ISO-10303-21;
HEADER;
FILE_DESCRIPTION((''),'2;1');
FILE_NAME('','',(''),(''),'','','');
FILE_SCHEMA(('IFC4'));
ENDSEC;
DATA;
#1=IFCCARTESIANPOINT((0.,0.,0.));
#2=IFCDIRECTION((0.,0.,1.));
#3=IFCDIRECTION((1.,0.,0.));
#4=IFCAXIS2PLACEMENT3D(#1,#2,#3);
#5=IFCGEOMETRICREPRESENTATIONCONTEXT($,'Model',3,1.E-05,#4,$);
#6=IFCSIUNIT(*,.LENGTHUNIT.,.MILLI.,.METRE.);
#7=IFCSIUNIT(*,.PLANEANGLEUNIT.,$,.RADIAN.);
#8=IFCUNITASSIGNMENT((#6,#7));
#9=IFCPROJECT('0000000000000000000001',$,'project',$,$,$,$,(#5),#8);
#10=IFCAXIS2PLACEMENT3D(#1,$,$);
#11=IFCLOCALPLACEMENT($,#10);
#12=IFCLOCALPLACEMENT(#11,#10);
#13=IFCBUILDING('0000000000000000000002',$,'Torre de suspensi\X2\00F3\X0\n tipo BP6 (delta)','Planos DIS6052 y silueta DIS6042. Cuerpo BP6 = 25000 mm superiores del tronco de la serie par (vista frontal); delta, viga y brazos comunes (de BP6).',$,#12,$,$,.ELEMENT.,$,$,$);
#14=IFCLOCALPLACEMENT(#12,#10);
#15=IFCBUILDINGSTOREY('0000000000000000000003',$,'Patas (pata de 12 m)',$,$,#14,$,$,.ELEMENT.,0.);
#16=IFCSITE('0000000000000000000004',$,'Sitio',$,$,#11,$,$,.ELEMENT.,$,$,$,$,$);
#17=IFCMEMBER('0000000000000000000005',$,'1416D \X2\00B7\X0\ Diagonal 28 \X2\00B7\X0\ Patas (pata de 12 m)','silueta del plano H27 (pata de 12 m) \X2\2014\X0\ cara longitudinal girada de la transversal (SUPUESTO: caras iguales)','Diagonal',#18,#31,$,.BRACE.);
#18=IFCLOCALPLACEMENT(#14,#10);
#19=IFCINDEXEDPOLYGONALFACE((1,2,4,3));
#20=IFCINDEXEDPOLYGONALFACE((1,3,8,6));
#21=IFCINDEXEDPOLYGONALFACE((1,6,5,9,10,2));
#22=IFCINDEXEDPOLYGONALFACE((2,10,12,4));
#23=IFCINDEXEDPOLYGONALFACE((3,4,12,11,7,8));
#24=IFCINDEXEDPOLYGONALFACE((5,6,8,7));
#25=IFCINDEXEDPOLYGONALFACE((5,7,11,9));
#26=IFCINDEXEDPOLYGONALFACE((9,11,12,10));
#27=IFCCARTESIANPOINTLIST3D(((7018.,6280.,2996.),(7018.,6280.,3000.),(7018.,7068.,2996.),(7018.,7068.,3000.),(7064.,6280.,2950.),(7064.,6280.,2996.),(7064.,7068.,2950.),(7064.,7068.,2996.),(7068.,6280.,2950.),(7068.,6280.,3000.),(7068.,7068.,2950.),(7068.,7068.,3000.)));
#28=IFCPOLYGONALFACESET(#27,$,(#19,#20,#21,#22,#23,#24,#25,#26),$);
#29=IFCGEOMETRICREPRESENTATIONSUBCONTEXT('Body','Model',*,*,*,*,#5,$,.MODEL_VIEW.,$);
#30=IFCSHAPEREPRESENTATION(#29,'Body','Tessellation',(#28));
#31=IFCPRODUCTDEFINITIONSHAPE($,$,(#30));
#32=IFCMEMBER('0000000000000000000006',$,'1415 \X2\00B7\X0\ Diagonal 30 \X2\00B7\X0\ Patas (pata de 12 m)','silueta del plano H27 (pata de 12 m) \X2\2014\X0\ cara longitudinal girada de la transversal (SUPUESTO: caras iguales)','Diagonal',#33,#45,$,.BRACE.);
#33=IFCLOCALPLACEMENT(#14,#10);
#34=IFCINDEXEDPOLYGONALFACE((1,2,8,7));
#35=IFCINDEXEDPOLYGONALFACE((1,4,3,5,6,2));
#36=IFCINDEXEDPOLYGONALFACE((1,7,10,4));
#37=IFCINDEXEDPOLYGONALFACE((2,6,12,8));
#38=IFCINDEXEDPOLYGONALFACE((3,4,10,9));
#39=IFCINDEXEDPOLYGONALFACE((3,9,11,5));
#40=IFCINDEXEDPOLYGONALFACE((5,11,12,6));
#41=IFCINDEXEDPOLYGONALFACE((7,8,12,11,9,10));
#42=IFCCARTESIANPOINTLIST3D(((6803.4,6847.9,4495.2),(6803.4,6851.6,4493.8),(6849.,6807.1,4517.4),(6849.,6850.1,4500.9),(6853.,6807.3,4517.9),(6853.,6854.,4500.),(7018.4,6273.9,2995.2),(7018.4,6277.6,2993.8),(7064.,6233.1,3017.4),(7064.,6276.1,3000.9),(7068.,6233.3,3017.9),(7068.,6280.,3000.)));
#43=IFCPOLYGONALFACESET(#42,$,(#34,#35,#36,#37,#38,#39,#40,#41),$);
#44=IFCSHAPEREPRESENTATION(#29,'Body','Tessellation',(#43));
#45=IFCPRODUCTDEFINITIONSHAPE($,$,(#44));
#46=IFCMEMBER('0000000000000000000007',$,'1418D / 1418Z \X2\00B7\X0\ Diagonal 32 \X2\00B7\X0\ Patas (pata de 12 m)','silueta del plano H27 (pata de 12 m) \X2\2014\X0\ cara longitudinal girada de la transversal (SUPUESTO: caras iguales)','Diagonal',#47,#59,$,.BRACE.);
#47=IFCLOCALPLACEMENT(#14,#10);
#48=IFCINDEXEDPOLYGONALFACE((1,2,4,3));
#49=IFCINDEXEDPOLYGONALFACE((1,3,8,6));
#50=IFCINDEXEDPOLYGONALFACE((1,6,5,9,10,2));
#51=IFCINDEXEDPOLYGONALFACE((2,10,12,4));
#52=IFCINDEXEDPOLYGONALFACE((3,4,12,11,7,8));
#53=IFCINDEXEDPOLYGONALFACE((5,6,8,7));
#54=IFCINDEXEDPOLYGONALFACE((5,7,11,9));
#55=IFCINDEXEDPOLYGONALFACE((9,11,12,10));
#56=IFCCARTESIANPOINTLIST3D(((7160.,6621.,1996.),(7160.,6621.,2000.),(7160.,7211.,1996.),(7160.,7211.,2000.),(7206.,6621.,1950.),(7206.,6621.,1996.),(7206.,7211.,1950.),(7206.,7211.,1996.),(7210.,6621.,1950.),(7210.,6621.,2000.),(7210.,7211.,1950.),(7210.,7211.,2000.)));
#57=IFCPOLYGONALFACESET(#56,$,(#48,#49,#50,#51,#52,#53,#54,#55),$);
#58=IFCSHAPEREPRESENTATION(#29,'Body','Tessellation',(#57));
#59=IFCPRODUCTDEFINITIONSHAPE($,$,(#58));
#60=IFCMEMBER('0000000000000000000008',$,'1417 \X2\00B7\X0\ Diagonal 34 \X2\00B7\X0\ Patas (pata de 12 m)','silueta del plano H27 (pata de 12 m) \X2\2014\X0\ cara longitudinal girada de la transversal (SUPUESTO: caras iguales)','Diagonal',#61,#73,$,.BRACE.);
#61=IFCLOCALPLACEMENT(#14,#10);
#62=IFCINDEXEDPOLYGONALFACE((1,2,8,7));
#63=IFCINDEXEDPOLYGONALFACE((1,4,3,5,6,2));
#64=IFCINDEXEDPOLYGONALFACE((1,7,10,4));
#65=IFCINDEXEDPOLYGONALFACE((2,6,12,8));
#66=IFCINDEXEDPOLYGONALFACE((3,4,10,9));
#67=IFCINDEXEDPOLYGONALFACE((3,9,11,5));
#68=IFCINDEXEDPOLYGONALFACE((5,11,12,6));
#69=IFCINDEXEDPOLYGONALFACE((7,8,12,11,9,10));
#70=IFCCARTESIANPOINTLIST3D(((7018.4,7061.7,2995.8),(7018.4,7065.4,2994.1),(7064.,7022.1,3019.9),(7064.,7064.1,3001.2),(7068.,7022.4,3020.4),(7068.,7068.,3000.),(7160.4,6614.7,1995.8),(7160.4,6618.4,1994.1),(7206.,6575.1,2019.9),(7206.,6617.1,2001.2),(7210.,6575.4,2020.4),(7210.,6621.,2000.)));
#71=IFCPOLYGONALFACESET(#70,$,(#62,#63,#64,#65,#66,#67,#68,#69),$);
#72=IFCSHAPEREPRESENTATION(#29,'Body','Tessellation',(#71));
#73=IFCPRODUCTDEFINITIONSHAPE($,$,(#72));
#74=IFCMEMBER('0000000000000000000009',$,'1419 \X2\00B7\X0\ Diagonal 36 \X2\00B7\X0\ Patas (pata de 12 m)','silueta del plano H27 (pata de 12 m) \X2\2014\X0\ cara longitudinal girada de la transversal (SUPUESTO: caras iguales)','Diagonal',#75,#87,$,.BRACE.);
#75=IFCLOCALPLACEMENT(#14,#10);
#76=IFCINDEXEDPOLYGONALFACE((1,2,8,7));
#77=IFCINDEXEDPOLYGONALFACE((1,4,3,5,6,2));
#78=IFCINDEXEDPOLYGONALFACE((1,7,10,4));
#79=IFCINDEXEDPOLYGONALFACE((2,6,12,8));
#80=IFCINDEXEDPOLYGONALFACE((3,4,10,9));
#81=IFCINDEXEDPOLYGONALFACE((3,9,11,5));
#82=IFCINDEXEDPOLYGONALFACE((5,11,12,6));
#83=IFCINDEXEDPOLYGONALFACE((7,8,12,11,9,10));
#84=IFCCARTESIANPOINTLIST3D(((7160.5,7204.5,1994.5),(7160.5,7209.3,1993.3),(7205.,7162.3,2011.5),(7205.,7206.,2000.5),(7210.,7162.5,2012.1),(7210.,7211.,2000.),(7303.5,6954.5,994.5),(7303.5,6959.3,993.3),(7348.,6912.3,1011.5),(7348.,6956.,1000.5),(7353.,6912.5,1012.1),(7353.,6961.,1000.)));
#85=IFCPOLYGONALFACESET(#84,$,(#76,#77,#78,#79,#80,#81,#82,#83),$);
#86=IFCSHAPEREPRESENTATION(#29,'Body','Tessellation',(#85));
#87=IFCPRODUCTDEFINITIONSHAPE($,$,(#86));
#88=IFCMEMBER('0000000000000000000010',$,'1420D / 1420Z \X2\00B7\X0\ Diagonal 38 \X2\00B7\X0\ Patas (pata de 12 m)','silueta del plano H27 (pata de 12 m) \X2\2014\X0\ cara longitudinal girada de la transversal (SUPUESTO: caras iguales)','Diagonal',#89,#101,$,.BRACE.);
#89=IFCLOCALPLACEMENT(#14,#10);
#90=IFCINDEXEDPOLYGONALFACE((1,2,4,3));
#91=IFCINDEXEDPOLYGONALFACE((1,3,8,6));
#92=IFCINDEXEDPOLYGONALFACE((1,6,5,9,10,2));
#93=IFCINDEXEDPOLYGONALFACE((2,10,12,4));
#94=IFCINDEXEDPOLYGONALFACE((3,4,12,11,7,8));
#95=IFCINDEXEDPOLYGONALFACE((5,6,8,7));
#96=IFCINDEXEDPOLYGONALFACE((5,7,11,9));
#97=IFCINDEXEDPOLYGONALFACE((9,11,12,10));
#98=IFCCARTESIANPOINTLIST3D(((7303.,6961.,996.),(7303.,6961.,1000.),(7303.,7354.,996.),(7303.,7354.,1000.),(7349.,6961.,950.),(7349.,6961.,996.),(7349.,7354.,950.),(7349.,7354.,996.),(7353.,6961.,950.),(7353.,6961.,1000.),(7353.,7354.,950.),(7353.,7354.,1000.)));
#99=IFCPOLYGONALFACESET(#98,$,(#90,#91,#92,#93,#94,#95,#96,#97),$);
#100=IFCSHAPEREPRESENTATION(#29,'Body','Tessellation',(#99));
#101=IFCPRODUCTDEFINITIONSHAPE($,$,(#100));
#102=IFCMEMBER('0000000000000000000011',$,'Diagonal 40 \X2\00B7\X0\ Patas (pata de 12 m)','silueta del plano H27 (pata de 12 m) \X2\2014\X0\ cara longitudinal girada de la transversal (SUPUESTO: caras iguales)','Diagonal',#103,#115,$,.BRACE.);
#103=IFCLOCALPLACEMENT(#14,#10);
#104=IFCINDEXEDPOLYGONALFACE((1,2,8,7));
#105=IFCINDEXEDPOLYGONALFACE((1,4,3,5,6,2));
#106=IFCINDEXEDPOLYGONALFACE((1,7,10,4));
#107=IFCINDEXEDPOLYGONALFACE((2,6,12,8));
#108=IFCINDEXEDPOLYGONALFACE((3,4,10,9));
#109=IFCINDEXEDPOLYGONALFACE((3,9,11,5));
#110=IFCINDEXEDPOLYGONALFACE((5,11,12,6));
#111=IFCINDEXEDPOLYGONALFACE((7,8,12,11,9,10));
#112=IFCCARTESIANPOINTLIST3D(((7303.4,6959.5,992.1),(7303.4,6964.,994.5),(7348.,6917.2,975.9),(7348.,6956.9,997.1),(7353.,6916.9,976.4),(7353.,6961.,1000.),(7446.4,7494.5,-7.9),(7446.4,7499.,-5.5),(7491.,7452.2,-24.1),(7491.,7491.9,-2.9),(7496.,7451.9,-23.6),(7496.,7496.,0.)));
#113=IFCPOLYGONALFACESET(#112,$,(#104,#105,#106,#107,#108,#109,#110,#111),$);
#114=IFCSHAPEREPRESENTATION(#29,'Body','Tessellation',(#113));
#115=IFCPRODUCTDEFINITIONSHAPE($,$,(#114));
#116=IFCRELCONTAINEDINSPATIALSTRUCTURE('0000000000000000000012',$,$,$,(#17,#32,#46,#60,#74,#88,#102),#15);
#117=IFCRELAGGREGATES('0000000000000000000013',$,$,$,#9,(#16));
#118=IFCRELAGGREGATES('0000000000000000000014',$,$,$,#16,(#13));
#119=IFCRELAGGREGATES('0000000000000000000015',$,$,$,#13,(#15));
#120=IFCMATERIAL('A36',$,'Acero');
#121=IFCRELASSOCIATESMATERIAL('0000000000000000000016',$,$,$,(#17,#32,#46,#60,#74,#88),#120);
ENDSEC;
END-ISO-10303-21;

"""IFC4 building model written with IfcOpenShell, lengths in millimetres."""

from ifc_helpers import new_model, si_unit, frame, frame_2d, origin, origin_with_axes, place, context, subcontext, project, spatial, l_section, extrude, material, element, save


model = new_model("IFC4")

# Units and contexts
model_context = context("Model", 3, precision=1e-05, world=origin_with_axes())
body_context = subcontext(model_context, "Body", "Model", "MODEL_VIEW")
ifc_project = project(units=[si_unit("LENGTHUNIT", "METRE", prefix="MILLI"), si_unit("PLANEANGLEUNIT", "RADIAN")], contexts=[model_context])

# Site, building, storey
site_placement = place(None, origin())
site = spatial("IfcSite", under=ifc_project, at=site_placement, Name="Sitio", CompositionType="ELEMENT")
building_placement = place(site_placement, origin())
building = spatial("IfcBuilding", under=site, at=building_placement, Name="Torre de suspensión tipo BP6 (delta)", Description="Planos DIS6052 y silueta DIS6042. Cuerpo BP6 = 25000 mm superiores del tronco de la serie par (vista frontal); delta, viga y brazos comunes (de BP6).", CompositionType="ELEMENT")
storey_placement = place(building_placement, origin())
storey = spatial("IfcBuildingStorey", under=building, at=storey_placement, Name="Patas (pata de 12 m)", CompositionType="ELEMENT", Elevation=0.0)

# Members
ifc_material = material(Name="A36", Category="Acero")
member_1_placement = place(storey_placement, frame((7068.0, 7068.0, 3000.0), z_axis=(0.0, -1.0, 0.0), x_axis=(-1.0, 0.0, 0.0)))
element("IfcMember", 1, at=member_1_placement, inside=storey, material=ifc_material, Name="1416D · Diagonal 28 · Patas (pata de 12 m)", Description="silueta del plano H27 (pata de 12 m) — cara longitudinal girada de la transversal (SUPUESTO: caras iguales)", ObjectType="Diagonal", PredefinedType="BRACE", context=body_context, shape_type="SweptSolid", body=[
    extrude(l_section(Depth=50.0, Width=50.0, Thickness=4.0, at=frame_2d((25.0, 25.0))), None, (0.0, 0.0, 1.0), 788.0),
])
member_2_placement = place(storey_placement, frame((7068.0, 6280.0, 3000.0), z_axis=(-0.132683, 0.354233, 0.925697), x_axis=(-0.991159, -0.04742, -0.12392)))
element("IfcMember", 2, at=member_2_placement, inside=storey, material=ifc_material, Name="1415 · Diagonal 30 · Patas (pata de 12 m)", Description="silueta del plano H27 (pata de 12 m) — cara longitudinal girada de la transversal (SUPUESTO: caras iguales)", ObjectType="Diagonal", PredefinedType="BRACE", context=body_context, shape_type="SweptSolid", body=[
    extrude(l_section(Depth=50.0, Width=50.0, Thickness=4.0, at=frame_2d((25.0, 25.0))), None, (0.0, 0.0, 1.0), 1620.4),
])
member_3_placement = place(storey_placement, frame((7210.0, 7211.0, 2000.0), z_axis=(0.0, -1.0, 0.0), x_axis=(-1.0, 0.0, 0.0)))
element("IfcMember", 3, at=member_3_placement, inside=storey, material=ifc_material, Name="1418D / 1418Z · Diagonal 32 · Patas (pata de 12 m)", Description="silueta del plano H27 (pata de 12 m) — cara longitudinal girada de la transversal (SUPUESTO: caras iguales)", ObjectType="Diagonal", PredefinedType="BRACE", context=body_context, shape_type="SweptSolid", body=[
    extrude(l_section(Depth=50.0, Width=50.0, Thickness=4.0, at=frame_2d((25.0, 25.0))), None, (0.0, 0.0, 1.0), 590.0),
])
member_4_placement = place(storey_placement, frame((7210.0, 6621.0, 2000.0), z_axis=(-0.128562, 0.404699, 0.905367), x_axis=(-0.991701, -0.052464, -0.11737)))
element("IfcMember", 4, at=member_4_placement, inside=storey, material=ifc_material, Name="1417 · Diagonal 34 · Patas (pata de 12 m)", Description="silueta del plano H27 (pata de 12 m) — cara longitudinal girada de la transversal (SUPUESTO: caras iguales)", ObjectType="Diagonal", PredefinedType="BRACE", context=body_context, shape_type="SweptSolid", body=[
    extrude(l_section(Depth=50.0, Width=50.0, Thickness=4.0, at=frame_2d((25.0, 25.0))), None, (0.0, 0.0, 1.0), 1104.5),
])
member_5_placement = place(storey_placement, frame((7353.0, 6961.0, 1000.0), z_axis=(-0.137414, 0.240235, 0.960939), x_axis=(-0.990514, -0.033328, -0.133311)))
element("IfcMember", 5, at=member_5_placement, inside=storey, material=ifc_material, Name="1419 · Diagonal 36 · Patas (pata de 12 m)", Description="silueta del plano H27 (pata de 12 m) — cara longitudinal girada de la transversal (SUPUESTO: caras iguales)", ObjectType="Diagonal", PredefinedType="BRACE", context=body_context, shape_type="SweptSolid", body=[
    extrude(l_section(Depth=50.0, Width=50.0, Thickness=5.0, at=frame_2d((25.0, 25.0))), None, (0.0, 0.0, 1.0), 1040.6),
])
member_6_placement = place(storey_placement, frame((7353.0, 7354.0, 1000.0), z_axis=(0.0, -1.0, 0.0), x_axis=(-1.0, 0.0, 0.0)))
element("IfcMember", 6, at=member_6_placement, inside=storey, material=ifc_material, Name="1420D / 1420Z · Diagonal 38 · Patas (pata de 12 m)", Description="silueta del plano H27 (pata de 12 m) — cara longitudinal girada de la transversal (SUPUESTO: caras iguales)", ObjectType="Diagonal", PredefinedType="BRACE", context=body_context, shape_type="SweptSolid", body=[
    extrude(l_section(Depth=50.0, Width=50.0, Thickness=4.0, at=frame_2d((25.0, 25.0))), None, (0.0, 0.0, 1.0), 393.0),
])
member_7_placement = place(storey_placement, frame((7496.0, 7496.0, 0.0), z_axis=(-0.125099, -0.468026, 0.874815), x_axis=(-0.992144, 0.059013, -0.110305)))
element("IfcMember", 7, at=member_7_placement, inside=storey, Name="Diagonal 40 · Patas (pata de 12 m)", Description="silueta del plano H27 (pata de 12 m) — cara longitudinal girada de la transversal (SUPUESTO: caras iguales)", ObjectType="Diagonal", PredefinedType="BRACE", context=body_context, shape_type="SweptSolid", body=[
    extrude(l_section(Depth=50.0, Width=50.0, Thickness=5.0, at=frame_2d((25.0, 25.0))), None, (0.0, 0.0, 1.0), 1143.1),
])

save(model, "model.ifc")
